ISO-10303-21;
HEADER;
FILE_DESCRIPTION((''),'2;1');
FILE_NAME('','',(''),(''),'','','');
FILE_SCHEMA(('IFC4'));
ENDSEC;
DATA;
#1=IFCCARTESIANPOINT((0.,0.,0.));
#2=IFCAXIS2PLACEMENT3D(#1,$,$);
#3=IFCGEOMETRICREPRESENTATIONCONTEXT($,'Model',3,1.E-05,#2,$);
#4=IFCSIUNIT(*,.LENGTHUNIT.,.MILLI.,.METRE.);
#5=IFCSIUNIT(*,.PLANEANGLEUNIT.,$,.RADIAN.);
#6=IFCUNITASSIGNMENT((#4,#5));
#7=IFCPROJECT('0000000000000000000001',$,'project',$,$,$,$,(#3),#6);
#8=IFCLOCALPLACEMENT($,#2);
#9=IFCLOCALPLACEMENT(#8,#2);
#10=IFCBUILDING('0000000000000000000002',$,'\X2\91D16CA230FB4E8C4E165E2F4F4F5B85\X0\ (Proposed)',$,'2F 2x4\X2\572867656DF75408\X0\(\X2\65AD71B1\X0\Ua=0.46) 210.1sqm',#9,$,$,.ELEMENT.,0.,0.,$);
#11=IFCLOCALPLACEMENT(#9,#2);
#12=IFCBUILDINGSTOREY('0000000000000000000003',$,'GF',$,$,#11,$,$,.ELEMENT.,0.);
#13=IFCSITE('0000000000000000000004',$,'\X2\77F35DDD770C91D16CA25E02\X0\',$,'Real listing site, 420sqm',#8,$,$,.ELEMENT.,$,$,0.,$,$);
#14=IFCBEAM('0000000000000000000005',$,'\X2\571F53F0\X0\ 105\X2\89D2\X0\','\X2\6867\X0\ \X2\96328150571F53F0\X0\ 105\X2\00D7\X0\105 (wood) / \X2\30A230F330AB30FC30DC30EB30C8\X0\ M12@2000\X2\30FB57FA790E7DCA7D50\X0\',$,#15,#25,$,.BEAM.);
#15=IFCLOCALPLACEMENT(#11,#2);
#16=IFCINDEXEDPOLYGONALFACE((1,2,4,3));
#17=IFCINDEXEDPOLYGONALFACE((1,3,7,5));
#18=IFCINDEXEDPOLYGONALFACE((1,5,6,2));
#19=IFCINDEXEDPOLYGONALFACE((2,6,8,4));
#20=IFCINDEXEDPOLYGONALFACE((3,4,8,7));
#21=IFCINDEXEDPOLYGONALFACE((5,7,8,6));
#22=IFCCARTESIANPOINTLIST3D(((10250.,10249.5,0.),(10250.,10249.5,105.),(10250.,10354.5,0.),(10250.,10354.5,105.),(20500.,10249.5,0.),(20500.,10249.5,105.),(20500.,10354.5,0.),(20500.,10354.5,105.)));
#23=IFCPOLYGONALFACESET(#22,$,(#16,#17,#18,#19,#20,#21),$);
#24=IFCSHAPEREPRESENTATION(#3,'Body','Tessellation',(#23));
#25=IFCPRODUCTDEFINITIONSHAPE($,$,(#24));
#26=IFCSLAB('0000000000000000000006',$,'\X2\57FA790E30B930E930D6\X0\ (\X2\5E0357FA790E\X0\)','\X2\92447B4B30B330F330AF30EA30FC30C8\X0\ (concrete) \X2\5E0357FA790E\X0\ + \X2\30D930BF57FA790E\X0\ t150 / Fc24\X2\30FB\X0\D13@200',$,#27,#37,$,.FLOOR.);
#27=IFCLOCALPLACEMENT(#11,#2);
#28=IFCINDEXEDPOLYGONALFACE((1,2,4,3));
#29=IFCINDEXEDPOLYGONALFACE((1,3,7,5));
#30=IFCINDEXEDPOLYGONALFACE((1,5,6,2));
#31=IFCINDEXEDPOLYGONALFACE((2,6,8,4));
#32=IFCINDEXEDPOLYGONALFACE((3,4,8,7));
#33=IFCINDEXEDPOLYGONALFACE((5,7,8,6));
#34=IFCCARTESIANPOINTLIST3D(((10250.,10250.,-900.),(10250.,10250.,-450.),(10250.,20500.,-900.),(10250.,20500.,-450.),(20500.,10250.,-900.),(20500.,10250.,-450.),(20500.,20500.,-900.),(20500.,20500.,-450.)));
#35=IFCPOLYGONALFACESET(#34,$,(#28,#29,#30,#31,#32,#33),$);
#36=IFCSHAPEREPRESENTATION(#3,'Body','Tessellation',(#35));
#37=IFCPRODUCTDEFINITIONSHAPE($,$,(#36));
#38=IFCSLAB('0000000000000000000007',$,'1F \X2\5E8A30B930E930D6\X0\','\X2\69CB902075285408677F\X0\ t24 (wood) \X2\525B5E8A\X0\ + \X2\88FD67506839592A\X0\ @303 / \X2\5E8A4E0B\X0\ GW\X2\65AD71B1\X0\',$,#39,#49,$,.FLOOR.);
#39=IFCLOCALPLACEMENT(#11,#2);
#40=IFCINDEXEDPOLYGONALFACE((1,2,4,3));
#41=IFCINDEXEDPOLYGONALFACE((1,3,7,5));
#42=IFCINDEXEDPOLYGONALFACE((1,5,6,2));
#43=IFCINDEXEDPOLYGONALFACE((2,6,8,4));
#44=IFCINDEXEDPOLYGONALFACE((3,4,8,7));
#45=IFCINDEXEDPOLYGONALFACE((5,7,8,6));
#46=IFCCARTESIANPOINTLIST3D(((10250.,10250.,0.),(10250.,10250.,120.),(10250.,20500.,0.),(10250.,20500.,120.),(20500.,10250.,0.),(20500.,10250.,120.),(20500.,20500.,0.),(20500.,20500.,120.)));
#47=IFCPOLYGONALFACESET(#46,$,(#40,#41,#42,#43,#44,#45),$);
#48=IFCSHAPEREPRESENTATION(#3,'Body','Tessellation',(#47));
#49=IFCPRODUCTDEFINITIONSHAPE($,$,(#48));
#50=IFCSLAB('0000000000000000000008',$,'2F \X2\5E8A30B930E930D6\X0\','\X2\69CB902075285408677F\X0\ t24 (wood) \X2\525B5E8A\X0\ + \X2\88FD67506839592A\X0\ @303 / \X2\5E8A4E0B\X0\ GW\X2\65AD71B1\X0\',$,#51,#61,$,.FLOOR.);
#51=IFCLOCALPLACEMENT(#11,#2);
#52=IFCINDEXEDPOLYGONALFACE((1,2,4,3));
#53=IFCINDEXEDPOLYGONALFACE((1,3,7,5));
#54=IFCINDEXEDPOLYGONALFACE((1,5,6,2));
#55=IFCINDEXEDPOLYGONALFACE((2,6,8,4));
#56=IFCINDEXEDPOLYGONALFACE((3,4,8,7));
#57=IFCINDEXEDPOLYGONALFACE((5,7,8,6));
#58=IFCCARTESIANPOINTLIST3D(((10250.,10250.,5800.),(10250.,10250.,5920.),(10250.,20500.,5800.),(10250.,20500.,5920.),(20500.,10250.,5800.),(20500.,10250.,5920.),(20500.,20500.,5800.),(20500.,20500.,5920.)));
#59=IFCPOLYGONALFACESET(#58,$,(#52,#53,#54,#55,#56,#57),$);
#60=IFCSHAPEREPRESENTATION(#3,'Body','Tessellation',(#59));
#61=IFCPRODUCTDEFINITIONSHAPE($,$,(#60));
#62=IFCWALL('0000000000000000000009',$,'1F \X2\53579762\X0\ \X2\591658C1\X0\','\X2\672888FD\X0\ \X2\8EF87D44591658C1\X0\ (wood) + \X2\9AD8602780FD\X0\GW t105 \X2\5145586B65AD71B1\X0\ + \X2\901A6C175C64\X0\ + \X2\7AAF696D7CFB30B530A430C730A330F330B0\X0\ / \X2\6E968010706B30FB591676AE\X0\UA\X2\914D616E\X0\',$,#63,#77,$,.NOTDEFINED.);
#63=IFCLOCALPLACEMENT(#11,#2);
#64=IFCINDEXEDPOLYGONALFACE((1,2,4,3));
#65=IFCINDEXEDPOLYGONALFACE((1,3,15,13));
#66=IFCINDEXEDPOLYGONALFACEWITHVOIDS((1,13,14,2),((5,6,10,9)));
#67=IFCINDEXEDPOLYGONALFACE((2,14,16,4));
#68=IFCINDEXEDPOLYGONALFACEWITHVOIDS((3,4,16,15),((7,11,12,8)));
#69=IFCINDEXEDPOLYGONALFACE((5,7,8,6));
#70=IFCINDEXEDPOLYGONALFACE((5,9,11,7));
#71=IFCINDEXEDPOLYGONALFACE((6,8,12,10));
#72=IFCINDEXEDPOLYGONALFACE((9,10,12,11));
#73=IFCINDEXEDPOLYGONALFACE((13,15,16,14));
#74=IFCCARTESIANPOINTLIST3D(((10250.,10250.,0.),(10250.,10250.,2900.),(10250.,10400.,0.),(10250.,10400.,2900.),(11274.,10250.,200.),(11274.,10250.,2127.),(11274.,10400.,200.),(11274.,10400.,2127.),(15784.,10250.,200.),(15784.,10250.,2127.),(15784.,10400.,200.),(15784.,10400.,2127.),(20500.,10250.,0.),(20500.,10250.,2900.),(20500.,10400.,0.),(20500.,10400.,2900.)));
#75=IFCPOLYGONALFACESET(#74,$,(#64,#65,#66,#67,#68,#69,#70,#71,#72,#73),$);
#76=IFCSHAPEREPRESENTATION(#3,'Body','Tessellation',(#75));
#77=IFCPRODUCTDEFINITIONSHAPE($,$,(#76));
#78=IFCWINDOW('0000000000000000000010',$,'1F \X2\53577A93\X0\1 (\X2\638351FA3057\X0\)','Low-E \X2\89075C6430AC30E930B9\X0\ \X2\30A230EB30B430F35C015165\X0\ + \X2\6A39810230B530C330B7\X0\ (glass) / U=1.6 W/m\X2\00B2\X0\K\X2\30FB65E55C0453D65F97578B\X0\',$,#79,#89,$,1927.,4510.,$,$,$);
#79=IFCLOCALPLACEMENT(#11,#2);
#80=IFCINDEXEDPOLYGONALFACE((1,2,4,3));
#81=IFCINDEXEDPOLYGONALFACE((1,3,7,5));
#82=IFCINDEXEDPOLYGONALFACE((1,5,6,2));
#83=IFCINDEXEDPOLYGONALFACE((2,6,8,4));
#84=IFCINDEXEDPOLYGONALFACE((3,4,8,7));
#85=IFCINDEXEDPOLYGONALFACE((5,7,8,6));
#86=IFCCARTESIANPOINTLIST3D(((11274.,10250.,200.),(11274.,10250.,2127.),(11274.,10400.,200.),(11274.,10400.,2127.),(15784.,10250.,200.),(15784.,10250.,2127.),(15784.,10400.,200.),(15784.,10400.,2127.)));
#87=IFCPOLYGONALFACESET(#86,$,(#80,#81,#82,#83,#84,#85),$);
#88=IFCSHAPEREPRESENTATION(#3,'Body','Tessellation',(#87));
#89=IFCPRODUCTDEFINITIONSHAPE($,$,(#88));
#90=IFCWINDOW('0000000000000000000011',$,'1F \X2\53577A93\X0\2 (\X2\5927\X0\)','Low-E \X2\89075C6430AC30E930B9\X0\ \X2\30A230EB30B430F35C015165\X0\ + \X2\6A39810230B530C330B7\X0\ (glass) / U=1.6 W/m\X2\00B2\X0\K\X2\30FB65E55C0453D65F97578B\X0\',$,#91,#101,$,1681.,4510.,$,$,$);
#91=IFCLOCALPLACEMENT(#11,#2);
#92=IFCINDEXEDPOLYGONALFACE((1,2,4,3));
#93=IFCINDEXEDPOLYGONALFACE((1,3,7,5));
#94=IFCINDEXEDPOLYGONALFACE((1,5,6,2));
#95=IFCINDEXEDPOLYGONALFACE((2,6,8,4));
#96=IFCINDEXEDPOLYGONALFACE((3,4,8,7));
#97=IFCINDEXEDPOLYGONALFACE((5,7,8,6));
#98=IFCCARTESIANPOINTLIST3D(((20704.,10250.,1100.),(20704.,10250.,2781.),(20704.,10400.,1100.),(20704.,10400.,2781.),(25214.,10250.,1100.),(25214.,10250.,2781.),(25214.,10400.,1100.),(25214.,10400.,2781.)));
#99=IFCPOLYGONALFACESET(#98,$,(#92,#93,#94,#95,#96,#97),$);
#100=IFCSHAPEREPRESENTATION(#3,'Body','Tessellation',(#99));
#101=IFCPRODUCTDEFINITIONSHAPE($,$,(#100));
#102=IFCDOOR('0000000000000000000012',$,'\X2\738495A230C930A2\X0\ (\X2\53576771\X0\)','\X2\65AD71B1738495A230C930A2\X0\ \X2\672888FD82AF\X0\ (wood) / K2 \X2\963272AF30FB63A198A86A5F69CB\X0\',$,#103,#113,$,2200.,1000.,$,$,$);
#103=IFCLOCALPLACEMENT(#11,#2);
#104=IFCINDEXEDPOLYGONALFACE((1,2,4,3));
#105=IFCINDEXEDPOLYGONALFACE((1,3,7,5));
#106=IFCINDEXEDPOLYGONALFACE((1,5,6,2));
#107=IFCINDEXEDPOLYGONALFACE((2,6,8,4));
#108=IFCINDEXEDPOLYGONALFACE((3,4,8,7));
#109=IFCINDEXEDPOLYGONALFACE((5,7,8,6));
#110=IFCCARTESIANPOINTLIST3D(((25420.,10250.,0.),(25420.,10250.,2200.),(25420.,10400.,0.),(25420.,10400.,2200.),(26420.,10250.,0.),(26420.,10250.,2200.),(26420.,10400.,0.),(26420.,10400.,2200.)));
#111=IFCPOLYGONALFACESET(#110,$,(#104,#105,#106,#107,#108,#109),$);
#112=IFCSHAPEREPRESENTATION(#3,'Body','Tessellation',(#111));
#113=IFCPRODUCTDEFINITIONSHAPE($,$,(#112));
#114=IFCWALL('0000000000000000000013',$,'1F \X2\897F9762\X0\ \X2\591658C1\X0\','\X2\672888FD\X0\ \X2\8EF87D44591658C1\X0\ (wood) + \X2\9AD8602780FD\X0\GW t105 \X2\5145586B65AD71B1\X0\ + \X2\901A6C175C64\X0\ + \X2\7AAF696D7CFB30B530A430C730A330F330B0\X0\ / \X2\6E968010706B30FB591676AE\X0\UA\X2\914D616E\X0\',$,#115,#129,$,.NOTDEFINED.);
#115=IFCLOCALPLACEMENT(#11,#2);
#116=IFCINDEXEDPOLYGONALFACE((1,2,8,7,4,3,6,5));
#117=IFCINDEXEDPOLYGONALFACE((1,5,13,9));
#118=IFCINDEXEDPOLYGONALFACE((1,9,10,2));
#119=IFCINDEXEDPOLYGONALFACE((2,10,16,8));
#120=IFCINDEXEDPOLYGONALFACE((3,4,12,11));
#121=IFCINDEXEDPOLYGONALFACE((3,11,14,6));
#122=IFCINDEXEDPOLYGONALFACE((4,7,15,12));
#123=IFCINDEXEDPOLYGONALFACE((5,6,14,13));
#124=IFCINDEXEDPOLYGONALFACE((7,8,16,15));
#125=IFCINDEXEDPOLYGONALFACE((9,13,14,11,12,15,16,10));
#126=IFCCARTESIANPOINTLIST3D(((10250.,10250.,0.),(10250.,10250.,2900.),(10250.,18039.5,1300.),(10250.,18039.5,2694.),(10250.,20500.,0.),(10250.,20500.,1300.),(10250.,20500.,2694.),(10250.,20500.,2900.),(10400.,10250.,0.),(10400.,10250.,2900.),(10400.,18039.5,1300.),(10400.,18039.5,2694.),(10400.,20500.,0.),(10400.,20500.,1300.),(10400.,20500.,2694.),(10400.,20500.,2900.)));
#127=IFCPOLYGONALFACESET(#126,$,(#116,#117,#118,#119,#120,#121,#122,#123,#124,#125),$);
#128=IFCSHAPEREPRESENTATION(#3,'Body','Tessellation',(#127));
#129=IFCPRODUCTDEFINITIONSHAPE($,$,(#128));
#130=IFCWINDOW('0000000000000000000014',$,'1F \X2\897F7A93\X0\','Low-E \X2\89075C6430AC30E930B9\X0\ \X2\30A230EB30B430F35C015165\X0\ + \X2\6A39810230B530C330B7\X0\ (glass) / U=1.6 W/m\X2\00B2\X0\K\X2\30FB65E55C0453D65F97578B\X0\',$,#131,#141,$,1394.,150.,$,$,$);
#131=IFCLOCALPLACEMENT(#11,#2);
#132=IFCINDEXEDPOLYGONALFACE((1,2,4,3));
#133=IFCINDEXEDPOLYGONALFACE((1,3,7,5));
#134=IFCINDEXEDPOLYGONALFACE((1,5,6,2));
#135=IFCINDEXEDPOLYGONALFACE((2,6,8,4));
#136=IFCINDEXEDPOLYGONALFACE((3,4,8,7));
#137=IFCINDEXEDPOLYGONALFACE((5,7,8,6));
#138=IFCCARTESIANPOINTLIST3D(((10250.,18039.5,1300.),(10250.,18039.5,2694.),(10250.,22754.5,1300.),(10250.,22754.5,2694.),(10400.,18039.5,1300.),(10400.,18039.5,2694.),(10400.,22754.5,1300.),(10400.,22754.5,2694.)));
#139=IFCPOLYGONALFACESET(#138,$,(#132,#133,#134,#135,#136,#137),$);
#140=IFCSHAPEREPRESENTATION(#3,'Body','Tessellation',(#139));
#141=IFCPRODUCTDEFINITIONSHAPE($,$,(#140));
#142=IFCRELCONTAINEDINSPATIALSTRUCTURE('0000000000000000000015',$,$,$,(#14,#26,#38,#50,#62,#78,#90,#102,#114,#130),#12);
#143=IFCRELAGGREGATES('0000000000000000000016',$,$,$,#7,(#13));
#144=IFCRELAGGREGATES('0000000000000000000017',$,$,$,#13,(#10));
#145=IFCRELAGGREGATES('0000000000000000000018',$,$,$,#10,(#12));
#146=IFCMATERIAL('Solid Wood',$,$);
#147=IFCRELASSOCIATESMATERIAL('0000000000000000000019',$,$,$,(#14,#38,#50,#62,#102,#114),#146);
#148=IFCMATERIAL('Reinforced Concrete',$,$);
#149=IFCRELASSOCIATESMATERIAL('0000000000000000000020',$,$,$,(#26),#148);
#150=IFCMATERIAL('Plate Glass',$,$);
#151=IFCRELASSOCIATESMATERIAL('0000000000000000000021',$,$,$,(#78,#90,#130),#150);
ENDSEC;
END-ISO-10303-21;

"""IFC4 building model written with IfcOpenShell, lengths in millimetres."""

from ifc_helpers import new_model, si_unit, frame, frame_2d, origin, place, context, project, spatial, rectangle, extrude, material, element, fill, save


model = new_model("IFC4")

# Units and contexts
model_context = context("Model", 3, precision=1e-05, world=origin())
ifc_project = project(units=[si_unit("LENGTHUNIT", "METRE", prefix="MILLI"), si_unit("PLANEANGLEUNIT", "RADIAN")], contexts=[model_context])

# Site, building, storey
site_placement = place(None, origin())
site = spatial("IfcSite", under=ifc_project, at=site_placement, Name="石川県金沢市", ObjectType="Real listing site, 420sqm", CompositionType="ELEMENT", RefElevation=0.0)
building_placement = place(site_placement, origin())
building = spatial("IfcBuilding", under=site, at=building_placement, Name="金沢・二世帯住宅 (Proposed)", ObjectType="2F 2x4在来混合(断熱Ua=0.46) 210.1sqm", CompositionType="ELEMENT", ElevationOfRefHeight=0.0, ElevationOfTerrain=0.0)
storey_placement = place(building_placement, origin())
storey = spatial("IfcBuildingStorey", under=building, at=storey_placement, Name="GF", CompositionType="ELEMENT", Elevation=0.0)

# Shared definitions
ifc_material_1 = material(Name="Solid Wood")

# Beam
beam_placement = place(storey_placement, frame((5125.0, 5125.0, 0.0)))
element("IfcBeam", 1, at=beam_placement, inside=storey, material=ifc_material_1, Name="土台 105角", Description="桧 防腐土台 105×105 (wood) / アンカーボルト M12@2000・基礎緊結", PredefinedType="BEAM", context=model_context, shape_type="SweptSolid", body=[
    extrude(rectangle(XDim=10250.0, YDim=105.0, at=frame_2d((5125.0, 52.0))), frame((5125.0, 5125.0, 0.0)), (0.0, 0.0, 1.0), 105.0),
])

# Slabs
ifc_material_2 = material(Name="Reinforced Concrete")
slab_1_placement = place(storey_placement, frame((5125.0, 5125.0, -450.0)))
element("IfcSlab", 2, at=slab_1_placement, inside=storey, material=ifc_material_2, Name="基礎スラブ (布基礎)", Description="鉄筋コンクリート (concrete) 布基礎 + ベタ基礎 t150 / Fc24・D13@200", PredefinedType="FLOOR", context=model_context, shape_type="SweptSolid", body=[
    extrude(rectangle(XDim=10250.0, YDim=10250.0, at=frame_2d((5125.0, 5125.0))), frame((5125.0, 5125.0, -450.0)), (0.0, 0.0, 1.0), 450.0),
])
slab_2_placement = place(storey_placement, frame((5125.0, 5125.0, 0.0)))
element("IfcSlab", 3, at=slab_2_placement, inside=storey, material=ifc_material_1, Name="1F 床スラブ", Description="構造用合板 t24 (wood) 剛床 + 製材根太 @303 / 床下 GW断熱", PredefinedType="FLOOR", context=model_context, shape_type="SweptSolid", body=[
    extrude(rectangle(XDim=10250.0, YDim=10250.0, at=frame_2d((5125.0, 5125.0))), frame((5125.0, 5125.0, 0.0)), (0.0, 0.0, 1.0), 120.0),
])
slab_3_placement = place(storey_placement, frame((5125.0, 5125.0, 2900.0)))
element("IfcSlab", 4, at=slab_3_placement, inside=storey, material=ifc_material_1, Name="2F 床スラブ", Description="構造用合板 t24 (wood) 剛床 + 製材根太 @303 / 床下 GW断熱", PredefinedType="FLOOR", context=model_context, shape_type="SweptSolid", body=[
    extrude(rectangle(XDim=10250.0, YDim=10250.0, at=frame_2d((5125.0, 5125.0))), frame((5125.0, 5125.0, 2900.0)), (0.0, 0.0, 1.0), 120.0),
])

# Wall, openings, windows, door
wall_1_placement = place(storey_placement, frame((5125.0, 5125.0, 0.0)))
wall_1 = element("IfcWall", 5, at=wall_1_placement, inside=storey, material=ifc_material_1, Name="1F 南面 外壁", Description="木製 軸組外壁 (wood) + 高性能GW t105 充填断熱 + 通気層 + 窯業系サイディング / 準耐火・外皮UA配慮", PredefinedType="NOTDEFINED", context=model_context, shape_type="SweptSolid", body=[
    extrude(rectangle(XDim=10250.0, YDim=150.0, at=frame_2d((5125.0, 75.0))), frame((5125.0, 5125.0, 0.0)), (0.0, 0.0, 1.0), 2900.0),
])
opening_1_placement = place(storey_placement, frame((5637.0, 5125.0, 100.0)))
opening_1 = element("IfcOpeningElement", 6, at=opening_1_placement, cuts=wall_1, PredefinedType="NOTDEFINED", context=model_context, shape_type="SweptSolid", body=[
    extrude(rectangle(XDim=4510.0, YDim=150.0, at=frame_2d((2255.0, 75.0))), frame((5637.0, 5125.0, 100.0)), (0.0, 0.0, 1.0), 1927.0),
])
opening_2_placement = place(storey_placement, frame((10352.0, 5125.0, 550.0)))
opening_2 = element("IfcOpeningElement", 7, at=opening_2_placement, cuts=wall_1, PredefinedType="NOTDEFINED", context=model_context, shape_type="SweptSolid", body=[
    extrude(rectangle(XDim=4510.0, YDim=150.0, at=frame_2d((2255.0, 75.0))), frame((10352.0, 5125.0, 550.0)), (0.0, 0.0, 1.0), 1681.0),
])
opening_3_placement = place(storey_placement, frame((12710.0, 5125.0, 0.0)))
opening_3 = element("IfcOpeningElement", 8, at=opening_3_placement, cuts=wall_1, PredefinedType="NOTDEFINED", context=model_context, shape_type="SweptSolid", body=[
    extrude(rectangle(XDim=1000.0, YDim=150.0, at=frame_2d((500.0, 75.0))), frame((12710.0, 5125.0, 0.0)), (0.0, 0.0, 1.0), 2200.0),
])
ifc_material_3 = material(Name="Plate Glass")
window_1_placement = place(storey_placement, frame((5637.0, 5125.0, 100.0)))
window_1 = element("IfcWindow", 9, at=window_1_placement, inside=storey, material=ifc_material_3, Name="1F 南窓1 (掃出し)", Description="Low-E 複層ガラス アルゴン封入 + 樹脂サッシ (glass) / U=1.6 W/m²K・日射取得型", OverallHeight=1927.0, OverallWidth=4510.0, context=model_context, shape_type="SweptSolid", body=[
    extrude(rectangle(XDim=4510.0, YDim=150.0, at=frame_2d((2255.0, 75.0))), frame((5637.0, 5125.0, 100.0)), (0.0, 0.0, 1.0), 1927.0),
])
fill(opening_1, window_1)
window_2_placement = place(storey_placement, frame((10352.0, 5125.0, 550.0)))
window_2 = element("IfcWindow", 10, at=window_2_placement, inside=storey, material=ifc_material_3, Name="1F 南窓2 (大)", Description="Low-E 複層ガラス アルゴン封入 + 樹脂サッシ (glass) / U=1.6 W/m²K・日射取得型", OverallHeight=1681.0, OverallWidth=4510.0, context=model_context, shape_type="SweptSolid", body=[
    extrude(rectangle(XDim=4510.0, YDim=150.0, at=frame_2d((2255.0, 75.0))), frame((10352.0, 5125.0, 550.0)), (0.0, 0.0, 1.0), 1681.0),
])
fill(opening_2, window_2)
door_placement = place(storey_placement, frame((12710.0, 5125.0, 0.0)))
door = element("IfcDoor", 11, at=door_placement, inside=storey, material=ifc_material_1, Name="玄関ドア (南東)", Description="断熱玄関ドア 木製芯 (wood) / K2 防犯・採風機構", OverallHeight=2200.0, OverallWidth=1000.0, context=model_context, shape_type="SweptSolid", body=[
    extrude(rectangle(XDim=1000.0, YDim=150.0, at=frame_2d((500.0, 75.0))), frame((12710.0, 5125.0, 0.0)), (0.0, 0.0, 1.0), 2200.0),
])
fill(opening_3, door)

# Wall, opening, window
wall_2_placement = place(storey_placement, frame((5125.0, 5125.0, 0.0)))
wall_2 = element("IfcWall", 12, at=wall_2_placement, inside=storey, material=ifc_material_1, Name="1F 西面 外壁", Description="木製 軸組外壁 (wood) + 高性能GW t105 充填断熱 + 通気層 + 窯業系サイディング / 準耐火・外皮UA配慮", PredefinedType="NOTDEFINED", context=model_context, shape_type="SweptSolid", body=[
    extrude(rectangle(XDim=150.0, YDim=10250.0, at=frame_2d((75.0, 5125.0))), frame((5125.0, 5125.0, 0.0)), (0.0, 0.0, 1.0), 2900.0),
])
opening_4_placement = place(storey_placement, frame((5125.0, 9020.0, 650.0)))
opening_4 = element("IfcOpeningElement", 13, at=opening_4_placement, cuts=wall_2, PredefinedType="NOTDEFINED", context=model_context, shape_type="SweptSolid", body=[
    extrude(rectangle(XDim=150.0, YDim=4715.0, at=frame_2d((75.0, 2357.0))), frame((5125.0, 9020.0, 650.0)), (0.0, 0.0, 1.0), 1394.0),
])
window_3_placement = place(storey_placement, frame((5125.0, 9020.0, 650.0)))
window_3 = element("IfcWindow", 14, at=window_3_placement, inside=storey, material=ifc_material_3, Name="1F 西窓", Description="Low-E 複層ガラス アルゴン封入 + 樹脂サッシ (glass) / U=1.6 W/m²K・日射取得型", OverallHeight=1394.0, OverallWidth=150.0, context=model_context, shape_type="SweptSolid", body=[
    extrude(rectangle(XDim=150.0, YDim=4715.0, at=frame_2d((75.0, 2357.0))), frame((5125.0, 9020.0, 650.0)), (0.0, 0.0, 1.0), 1394.0),
])
fill(opening_4, window_3)

save(model, "model.ifc")
